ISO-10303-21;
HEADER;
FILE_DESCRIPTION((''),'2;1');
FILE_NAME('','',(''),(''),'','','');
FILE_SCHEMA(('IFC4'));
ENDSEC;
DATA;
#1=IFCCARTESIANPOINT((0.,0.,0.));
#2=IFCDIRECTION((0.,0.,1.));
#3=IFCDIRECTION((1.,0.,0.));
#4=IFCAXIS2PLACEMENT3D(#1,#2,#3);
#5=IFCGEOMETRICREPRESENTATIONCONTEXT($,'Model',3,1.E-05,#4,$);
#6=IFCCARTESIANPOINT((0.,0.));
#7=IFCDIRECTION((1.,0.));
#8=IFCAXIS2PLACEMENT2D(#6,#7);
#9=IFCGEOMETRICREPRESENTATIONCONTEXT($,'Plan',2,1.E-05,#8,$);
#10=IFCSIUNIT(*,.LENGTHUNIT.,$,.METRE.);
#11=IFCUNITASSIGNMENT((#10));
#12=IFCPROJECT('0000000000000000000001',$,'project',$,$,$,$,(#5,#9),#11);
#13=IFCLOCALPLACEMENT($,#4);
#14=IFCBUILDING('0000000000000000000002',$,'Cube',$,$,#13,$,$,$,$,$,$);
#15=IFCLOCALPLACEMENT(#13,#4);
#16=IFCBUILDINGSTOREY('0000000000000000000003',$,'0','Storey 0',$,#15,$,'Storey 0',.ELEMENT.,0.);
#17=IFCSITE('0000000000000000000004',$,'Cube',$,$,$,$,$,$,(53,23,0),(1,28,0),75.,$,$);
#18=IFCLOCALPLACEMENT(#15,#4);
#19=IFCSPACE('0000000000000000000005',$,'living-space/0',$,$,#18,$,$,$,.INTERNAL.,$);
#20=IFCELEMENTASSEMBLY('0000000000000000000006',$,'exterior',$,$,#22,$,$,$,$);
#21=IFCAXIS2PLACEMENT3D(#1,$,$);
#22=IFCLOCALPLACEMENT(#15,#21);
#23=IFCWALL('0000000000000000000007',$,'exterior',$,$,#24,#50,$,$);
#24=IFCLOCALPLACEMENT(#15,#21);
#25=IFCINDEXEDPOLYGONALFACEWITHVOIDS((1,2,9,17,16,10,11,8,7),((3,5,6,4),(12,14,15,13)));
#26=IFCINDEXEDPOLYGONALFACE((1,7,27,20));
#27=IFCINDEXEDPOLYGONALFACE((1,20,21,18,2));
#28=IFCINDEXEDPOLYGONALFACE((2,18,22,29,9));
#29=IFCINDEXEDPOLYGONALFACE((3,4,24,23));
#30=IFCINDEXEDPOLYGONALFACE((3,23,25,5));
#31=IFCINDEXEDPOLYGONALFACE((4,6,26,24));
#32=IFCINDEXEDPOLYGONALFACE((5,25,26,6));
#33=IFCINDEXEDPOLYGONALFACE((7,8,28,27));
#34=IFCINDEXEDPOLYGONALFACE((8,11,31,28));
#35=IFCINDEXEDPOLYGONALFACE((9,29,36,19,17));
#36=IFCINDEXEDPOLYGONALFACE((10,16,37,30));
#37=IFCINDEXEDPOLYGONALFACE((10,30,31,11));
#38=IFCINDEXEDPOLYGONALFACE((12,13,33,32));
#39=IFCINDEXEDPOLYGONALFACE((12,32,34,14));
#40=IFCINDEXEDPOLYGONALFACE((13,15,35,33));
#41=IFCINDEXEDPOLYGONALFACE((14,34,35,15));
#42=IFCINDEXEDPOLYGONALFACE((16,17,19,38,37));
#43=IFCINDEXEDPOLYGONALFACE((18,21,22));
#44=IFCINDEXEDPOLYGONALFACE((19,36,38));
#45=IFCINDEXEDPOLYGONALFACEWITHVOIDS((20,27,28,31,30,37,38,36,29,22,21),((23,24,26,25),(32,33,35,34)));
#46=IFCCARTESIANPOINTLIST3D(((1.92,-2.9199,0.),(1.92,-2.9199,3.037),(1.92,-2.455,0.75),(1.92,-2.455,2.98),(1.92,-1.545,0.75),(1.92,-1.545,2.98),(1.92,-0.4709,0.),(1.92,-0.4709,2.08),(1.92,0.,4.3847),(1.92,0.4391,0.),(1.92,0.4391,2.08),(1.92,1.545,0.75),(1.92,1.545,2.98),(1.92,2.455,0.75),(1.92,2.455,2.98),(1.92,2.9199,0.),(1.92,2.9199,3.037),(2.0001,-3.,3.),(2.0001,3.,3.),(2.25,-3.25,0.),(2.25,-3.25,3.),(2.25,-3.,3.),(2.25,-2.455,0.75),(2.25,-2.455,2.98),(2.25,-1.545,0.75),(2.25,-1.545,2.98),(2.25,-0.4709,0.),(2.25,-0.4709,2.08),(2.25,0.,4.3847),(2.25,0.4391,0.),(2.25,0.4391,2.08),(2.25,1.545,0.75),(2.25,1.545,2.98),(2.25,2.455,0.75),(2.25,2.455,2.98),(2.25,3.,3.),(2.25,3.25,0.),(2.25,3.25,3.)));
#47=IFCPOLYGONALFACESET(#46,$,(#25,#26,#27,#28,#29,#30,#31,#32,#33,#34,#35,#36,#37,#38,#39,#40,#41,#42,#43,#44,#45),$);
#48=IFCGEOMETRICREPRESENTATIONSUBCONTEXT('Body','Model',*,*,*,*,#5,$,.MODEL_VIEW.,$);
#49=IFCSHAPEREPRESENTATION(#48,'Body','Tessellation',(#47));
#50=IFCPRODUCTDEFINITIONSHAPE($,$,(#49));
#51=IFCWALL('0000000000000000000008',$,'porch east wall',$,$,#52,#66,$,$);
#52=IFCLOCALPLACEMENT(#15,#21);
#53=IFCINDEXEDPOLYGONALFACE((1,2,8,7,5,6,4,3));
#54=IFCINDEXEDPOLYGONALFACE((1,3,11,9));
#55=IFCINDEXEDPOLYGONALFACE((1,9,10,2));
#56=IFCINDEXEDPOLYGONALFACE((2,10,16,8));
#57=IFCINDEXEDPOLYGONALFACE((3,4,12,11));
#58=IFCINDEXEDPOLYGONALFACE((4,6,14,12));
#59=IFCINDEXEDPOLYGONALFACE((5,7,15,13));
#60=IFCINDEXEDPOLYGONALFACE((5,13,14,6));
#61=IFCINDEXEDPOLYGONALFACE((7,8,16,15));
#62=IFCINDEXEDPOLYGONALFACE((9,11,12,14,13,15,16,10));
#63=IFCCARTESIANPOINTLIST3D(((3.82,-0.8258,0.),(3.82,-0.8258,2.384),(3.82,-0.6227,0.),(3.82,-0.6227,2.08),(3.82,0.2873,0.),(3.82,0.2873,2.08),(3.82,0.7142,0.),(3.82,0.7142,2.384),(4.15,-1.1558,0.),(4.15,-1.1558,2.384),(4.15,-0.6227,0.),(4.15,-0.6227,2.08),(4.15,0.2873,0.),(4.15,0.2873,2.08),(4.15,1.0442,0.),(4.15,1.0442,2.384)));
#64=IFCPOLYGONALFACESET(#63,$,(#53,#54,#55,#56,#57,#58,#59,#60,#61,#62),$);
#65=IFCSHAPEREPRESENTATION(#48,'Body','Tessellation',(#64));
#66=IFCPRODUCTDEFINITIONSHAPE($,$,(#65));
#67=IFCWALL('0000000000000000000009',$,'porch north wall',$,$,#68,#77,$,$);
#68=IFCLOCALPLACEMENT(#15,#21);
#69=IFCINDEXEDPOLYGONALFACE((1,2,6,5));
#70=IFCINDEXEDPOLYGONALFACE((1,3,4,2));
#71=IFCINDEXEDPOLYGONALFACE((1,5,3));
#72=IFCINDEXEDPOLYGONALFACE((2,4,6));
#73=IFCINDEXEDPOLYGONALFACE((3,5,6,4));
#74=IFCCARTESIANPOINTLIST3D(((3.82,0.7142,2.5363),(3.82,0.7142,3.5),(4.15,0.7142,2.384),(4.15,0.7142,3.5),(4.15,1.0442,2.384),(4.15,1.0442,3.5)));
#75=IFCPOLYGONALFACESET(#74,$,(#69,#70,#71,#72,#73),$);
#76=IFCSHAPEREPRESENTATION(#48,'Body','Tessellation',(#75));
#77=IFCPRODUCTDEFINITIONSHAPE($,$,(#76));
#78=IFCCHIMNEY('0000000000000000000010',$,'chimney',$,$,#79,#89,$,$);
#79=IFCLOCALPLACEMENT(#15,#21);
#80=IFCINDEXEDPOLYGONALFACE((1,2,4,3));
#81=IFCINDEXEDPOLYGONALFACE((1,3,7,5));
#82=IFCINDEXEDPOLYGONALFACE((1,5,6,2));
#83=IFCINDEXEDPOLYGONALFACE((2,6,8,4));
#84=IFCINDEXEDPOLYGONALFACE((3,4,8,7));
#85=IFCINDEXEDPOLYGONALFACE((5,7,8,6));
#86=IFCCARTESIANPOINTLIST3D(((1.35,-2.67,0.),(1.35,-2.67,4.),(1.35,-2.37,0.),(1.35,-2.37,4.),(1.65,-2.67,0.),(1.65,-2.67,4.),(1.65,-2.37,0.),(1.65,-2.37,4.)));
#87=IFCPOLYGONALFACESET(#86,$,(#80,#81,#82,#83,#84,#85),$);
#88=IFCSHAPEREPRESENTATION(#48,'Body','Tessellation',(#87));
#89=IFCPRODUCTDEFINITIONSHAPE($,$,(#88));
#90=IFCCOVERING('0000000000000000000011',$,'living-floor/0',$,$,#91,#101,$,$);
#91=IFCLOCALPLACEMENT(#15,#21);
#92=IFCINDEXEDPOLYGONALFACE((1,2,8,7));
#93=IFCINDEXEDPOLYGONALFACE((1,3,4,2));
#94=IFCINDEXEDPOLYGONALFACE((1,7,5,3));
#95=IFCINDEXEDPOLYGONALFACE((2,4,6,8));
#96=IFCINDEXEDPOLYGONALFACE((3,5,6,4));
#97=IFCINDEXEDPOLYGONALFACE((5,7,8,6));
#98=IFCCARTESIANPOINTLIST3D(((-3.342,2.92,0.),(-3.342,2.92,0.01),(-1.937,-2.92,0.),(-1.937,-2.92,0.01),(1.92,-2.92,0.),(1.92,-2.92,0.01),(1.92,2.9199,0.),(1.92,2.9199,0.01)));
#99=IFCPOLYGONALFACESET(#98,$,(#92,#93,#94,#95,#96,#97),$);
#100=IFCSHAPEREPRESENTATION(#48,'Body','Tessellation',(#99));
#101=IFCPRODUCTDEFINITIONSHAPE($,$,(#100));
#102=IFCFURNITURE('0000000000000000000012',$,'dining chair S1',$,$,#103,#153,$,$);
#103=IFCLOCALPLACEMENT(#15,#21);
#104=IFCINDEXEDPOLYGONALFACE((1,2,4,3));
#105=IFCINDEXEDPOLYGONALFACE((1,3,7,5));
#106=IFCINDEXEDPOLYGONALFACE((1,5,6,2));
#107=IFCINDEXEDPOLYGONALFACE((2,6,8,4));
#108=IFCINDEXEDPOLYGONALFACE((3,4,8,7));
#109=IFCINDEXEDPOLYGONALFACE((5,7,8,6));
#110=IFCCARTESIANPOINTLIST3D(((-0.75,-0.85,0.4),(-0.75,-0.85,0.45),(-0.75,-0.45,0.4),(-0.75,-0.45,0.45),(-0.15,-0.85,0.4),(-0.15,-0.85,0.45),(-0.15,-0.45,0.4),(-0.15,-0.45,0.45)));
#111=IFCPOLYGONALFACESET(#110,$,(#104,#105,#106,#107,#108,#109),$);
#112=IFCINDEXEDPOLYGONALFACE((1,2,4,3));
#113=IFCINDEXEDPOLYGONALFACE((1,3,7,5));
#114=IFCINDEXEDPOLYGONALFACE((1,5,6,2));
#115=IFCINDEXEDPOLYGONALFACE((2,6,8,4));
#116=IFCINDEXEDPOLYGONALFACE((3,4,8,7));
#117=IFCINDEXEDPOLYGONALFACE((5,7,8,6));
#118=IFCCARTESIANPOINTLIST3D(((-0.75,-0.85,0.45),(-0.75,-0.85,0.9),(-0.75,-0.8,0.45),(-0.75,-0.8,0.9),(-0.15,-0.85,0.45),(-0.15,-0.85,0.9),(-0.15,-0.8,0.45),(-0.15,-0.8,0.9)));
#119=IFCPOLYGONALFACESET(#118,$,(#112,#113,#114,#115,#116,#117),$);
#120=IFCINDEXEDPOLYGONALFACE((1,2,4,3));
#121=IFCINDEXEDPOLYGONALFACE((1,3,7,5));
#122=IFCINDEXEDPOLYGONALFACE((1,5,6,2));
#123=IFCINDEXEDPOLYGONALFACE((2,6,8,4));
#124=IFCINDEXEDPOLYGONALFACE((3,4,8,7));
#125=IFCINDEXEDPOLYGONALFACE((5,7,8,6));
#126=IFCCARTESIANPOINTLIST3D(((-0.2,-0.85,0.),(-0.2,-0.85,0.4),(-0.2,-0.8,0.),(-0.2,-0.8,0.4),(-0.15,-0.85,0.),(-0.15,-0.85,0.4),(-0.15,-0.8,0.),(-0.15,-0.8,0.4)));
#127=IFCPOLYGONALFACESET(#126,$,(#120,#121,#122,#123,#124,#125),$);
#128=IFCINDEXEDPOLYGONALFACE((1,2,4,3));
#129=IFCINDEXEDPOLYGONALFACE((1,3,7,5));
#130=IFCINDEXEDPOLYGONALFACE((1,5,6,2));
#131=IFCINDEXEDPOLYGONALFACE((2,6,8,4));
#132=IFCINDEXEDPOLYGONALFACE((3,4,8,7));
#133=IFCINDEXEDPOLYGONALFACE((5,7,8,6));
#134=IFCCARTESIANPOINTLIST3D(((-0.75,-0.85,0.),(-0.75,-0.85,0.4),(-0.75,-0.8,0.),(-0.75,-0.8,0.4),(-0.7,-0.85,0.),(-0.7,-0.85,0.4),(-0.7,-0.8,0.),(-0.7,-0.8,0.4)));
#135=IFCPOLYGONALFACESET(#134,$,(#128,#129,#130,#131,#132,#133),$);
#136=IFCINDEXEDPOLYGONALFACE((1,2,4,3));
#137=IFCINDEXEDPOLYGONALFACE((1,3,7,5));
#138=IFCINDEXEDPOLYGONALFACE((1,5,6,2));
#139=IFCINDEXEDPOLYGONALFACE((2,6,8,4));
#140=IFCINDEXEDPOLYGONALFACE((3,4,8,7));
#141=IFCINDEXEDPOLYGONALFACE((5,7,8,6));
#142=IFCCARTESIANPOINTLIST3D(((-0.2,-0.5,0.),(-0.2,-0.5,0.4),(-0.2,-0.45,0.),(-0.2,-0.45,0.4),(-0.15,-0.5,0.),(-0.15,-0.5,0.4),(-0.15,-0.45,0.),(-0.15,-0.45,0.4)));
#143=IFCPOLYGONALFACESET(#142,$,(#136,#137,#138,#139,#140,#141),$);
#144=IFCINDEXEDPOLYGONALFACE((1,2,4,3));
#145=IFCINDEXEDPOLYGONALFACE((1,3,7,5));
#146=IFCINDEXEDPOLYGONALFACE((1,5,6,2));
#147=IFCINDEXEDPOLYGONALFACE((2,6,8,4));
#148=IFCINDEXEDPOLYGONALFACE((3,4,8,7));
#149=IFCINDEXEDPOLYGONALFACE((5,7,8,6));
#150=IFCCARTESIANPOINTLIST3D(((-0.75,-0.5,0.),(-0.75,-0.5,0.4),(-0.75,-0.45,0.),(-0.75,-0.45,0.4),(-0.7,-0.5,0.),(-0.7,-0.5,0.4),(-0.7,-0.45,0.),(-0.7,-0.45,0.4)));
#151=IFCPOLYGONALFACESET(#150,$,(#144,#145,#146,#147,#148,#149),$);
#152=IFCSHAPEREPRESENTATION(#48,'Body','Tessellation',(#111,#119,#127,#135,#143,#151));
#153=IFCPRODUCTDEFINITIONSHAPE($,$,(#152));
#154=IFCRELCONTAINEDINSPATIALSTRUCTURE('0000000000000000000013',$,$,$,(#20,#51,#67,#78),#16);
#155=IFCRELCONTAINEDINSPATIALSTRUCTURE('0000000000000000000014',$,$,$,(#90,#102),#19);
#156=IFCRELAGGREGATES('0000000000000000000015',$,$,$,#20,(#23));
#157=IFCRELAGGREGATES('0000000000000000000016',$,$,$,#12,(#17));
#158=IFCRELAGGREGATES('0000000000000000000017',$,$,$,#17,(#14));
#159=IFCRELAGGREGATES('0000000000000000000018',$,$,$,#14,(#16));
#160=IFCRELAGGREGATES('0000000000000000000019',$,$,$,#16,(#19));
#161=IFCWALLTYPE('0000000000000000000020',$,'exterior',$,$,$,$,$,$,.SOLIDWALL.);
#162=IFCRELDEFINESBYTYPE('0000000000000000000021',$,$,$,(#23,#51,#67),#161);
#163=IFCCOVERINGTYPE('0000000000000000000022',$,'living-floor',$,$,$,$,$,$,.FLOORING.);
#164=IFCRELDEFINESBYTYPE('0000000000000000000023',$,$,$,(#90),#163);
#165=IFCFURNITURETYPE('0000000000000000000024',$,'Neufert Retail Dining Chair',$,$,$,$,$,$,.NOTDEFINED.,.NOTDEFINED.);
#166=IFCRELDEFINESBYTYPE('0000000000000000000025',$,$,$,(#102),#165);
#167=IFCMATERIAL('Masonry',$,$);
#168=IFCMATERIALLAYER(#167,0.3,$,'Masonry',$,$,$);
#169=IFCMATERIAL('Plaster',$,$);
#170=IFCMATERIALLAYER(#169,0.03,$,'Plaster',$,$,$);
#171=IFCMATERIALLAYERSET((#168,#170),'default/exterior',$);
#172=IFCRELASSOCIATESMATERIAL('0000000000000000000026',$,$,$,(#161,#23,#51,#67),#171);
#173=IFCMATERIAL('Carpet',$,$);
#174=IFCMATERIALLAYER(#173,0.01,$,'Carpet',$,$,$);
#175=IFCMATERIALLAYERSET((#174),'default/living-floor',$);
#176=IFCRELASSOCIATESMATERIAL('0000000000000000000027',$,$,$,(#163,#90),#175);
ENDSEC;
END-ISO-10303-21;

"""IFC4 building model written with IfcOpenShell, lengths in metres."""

from ifc_helpers import new_model, entity, si_unit, frame, origin, origin_with_axes, origin_2d_with_axis, place, context, subcontext, project, spatial, polyline, line, indexed_curve, outline, extrude, clip, halfspace, bounded_halfspace, shape, source, transform, mapped, material, layer, layer_set, layer_usage, type_object, type_shapes, element, aggregate, save


model = new_model("IFC4")

# Units and contexts
model_context = context("Model", 3, precision=1e-05, world=origin_with_axes())
plan_context = context("Plan", 2, precision=1e-05, world=origin_2d_with_axis())
body_context_1 = subcontext(model_context, "Body", "Model", "MODEL_VIEW")
body_context_2 = subcontext(plan_context, "Body", "Plan", "PLAN_VIEW")
ifc_project = project(units=[si_unit("LENGTHUNIT", "METRE")], contexts=[model_context, plan_context])

# Site, building, storey
site = spatial("IfcSite", under=ifc_project, Name="Cube", RefLatitude=(53, 23, 0), RefLongitude=(1, 28, 0), RefElevation=75.0)
building_placement = place(None, origin_with_axes())
building = spatial("IfcBuilding", under=site, at=building_placement, Name="Cube")
storey_placement = place(building_placement, origin_with_axes())
storey = spatial("IfcBuildingStorey", under=building, at=storey_placement, Name="0", Description="Storey 0", LongName="Storey 0", CompositionType="ELEMENT", Elevation=0.0)

# Element assembly, wall, openings
ifc_material_1 = material(Name="Masonry")
ifc_layer_1 = layer(ifc_material_1, 0.3, Name="Masonry")
ifc_material_2 = material(Name="Plaster")
ifc_layer_2 = layer(ifc_material_2, 0.03, Name="Plaster")
ifc_layer_set_1 = layer_set([ifc_layer_1, ifc_layer_2], Name="default/exterior")
wall_type = type_object("IfcWallType", Name="exterior", PredefinedType="SOLIDWALL", material=ifc_layer_set_1)
assembly_1_placement = place(storey_placement, frame((2.0, -3.0, 0.0), z_axis=(0.0, 0.0, 1.0), x_axis=(0.0, 1.0, 0.0)))
assembly_1 = element("IfcElementAssembly", 1, at=assembly_1_placement, inside=storey, Name="exterior")
ifc_layer_usage_1 = layer_usage(ifc_layer_set_1, "AXIS2", "POSITIVE", -0.25)
wall_1_placement = place(assembly_1_placement, origin_with_axes())
wall_1 = element("IfcWall", 2, at=wall_1_placement, type_object=wall_type, material=ifc_layer_usage_1, Name="exterior", context=body_context_1, shape_type="Clipping", body=[
    clip(clip(clip(clip(extrude(outline(polyline([(0.0801, 0.08), (-0.25, -0.25), (6.25, -0.25), (5.9199, 0.08), (0.0801, 0.08)])), origin(), (0.0, 0.0, 1.0), 4.385), bounded_halfspace(frame((6.0, 0.0, 3.0), z_axis=(0.419069, 0.0, 0.907954), x_axis=(0.0, -1.0, 0.0)), False, origin(), polyline([(6.0, -1.0), (3.0, -1.0), (3.0, 1.0), (6.0, 1.0), (6.0, -1.0)]))), bounded_halfspace(frame((6.0, 0.0, 3.0), z_axis=(0.0, 0.0, 1.0), x_axis=(0.0, 1.0, 0.0)), False, origin(), polyline([(6.0, 1.0), (7.0, 1.0), (7.0, -1.0), (6.0, -1.0), (6.0, 1.0)]))), bounded_halfspace(frame((3.0, 0.0, 4.3847), z_axis=(-0.419069, 0.0, 0.907954), x_axis=(0.0, -1.0, 0.0)), False, origin(), polyline([(3.0, -1.0), (0.0, -1.0), (0.0, 1.0), (3.0, 1.0), (3.0, -1.0)]))), bounded_halfspace(frame((0.0, 0.0, 3.0), z_axis=(0.0, 0.0, 1.0), x_axis=(0.0, -1.0, 0.0)), False, origin(), polyline([(0.0, -1.0), (-1.0, -1.0), (-1.0, 1.0), (0.0, 1.0), (0.0, -1.0)]))),
])
opening_1_placement = place(wall_1_placement, frame((0.545, -0.25, 0.75), z_axis=(0.0, 0.0, 1.0), x_axis=(1.0, 0.0, 0.0)))
element("IfcOpeningElement", 3, at=opening_1_placement, cuts=wall_1, PredefinedType="OPENING", context=body_context_1, shape_type="SweptSolid", body=[
    extrude(outline(polyline([(0.0, -0.02), (0.91, -0.02), (0.91, 0.35), (0.0, 0.35), (0.0, -0.02)])), origin(), (0.0, 0.0, 1.0), 2.23),
])
opening_2_placement = place(wall_1_placement, frame((4.545, -0.25, 0.75), z_axis=(0.0, 0.0, 1.0), x_axis=(1.0, 0.0, 0.0)))
element("IfcOpeningElement", 4, at=opening_2_placement, cuts=wall_1, PredefinedType="OPENING", context=body_context_1, shape_type="SweptSolid", body=[
    extrude(outline(polyline([(0.0, -0.02), (0.91, -0.02), (0.91, 0.35), (0.0, 0.35), (0.0, -0.02)])), origin(), (0.0, 0.0, 1.0), 2.23),
])
shared_shape_1 = source(origin_with_axes(), body_context_1, "Body", "SweptSolid", [
    extrude(outline(indexed_curve([(0.0, 0.0), (0.91, 0.0), (0.91, 2.08), (0.0, 2.08)], segments=[line(1, 2, 3, 4, 1)])), frame((0.0, -0.6, 0.0), z_axis=(0.0, -1.0, 0.0), x_axis=(1.0, 0.0, 0.0)), (0.0, 0.0, -1.0), 1.2),
])
opening_3_placement = place(wall_1_placement, frame((2.5291, -0.25, 0.0), z_axis=(0.0, 0.0, 1.0), x_axis=(1.0, 0.0, 0.0)))
element("IfcOpeningElement", 5, at=opening_3_placement, cuts=wall_1, PredefinedType="OPENING", context=body_context_1, shape_type="MappedRepresentation", body=[
    mapped(shared_shape_1, transform((0.0, 0.0, 0.0), x_axis=(1.0, 0.0, 0.0), y_axis=(0.0, 1.0, 0.0), z_axis=(0.0, 0.0, 1.0), scale=1.0)),
])
aggregate(assembly_1, [wall_1])

# Wall, opening
ifc_layer_usage_2 = layer_usage(ifc_layer_set_1, "AXIS2", "POSITIVE", 0.0)
wall_2_placement = place(storey_placement, frame((4.15, -1.1558, 0.0), z_axis=(0.0, 0.0, 1.0), x_axis=(0.0, 1.0, 0.0)))
wall_2 = element("IfcWall", 6, at=wall_2_placement, inside=storey, type_object=wall_type, material=ifc_layer_usage_2, Name="porch east wall", context=body_context_1, shape_type="SweptSolid", body=[
    extrude(outline(indexed_curve([(0.0, 0.0), (0.33, 0.33), (1.87, 0.33), (2.2, 0.0)], segments=[line(1, 2, 3, 4, 1)])), origin_with_axes(), (0.0, 0.0, 1.0), 2.384),
])
shared_shape_2 = source(origin_with_axes(), body_context_1, "Body", "SweptSolid", [
    extrude(outline(indexed_curve([(0.0, 0.0), (0.91, 0.0), (0.91, 2.08), (0.0, 2.08)], segments=[line(1, 2, 3, 4, 1)])), frame((0.0, -0.6, 0.0), z_axis=(0.0, -1.0, 0.0), x_axis=(1.0, 0.0, 0.0)), (0.0, 0.0, -1.0), 1.2),
])
opening_4_placement = place(wall_2_placement, frame((0.5331, 0.0, 0.0), z_axis=(0.0, 0.0, 1.0), x_axis=(1.0, 0.0, 0.0)))
element("IfcOpeningElement", 7, at=opening_4_placement, cuts=wall_2, PredefinedType="OPENING", context=body_context_1, shape_type="MappedRepresentation", body=[
    mapped(shared_shape_2, transform((0.0, 0.0, 0.0), x_axis=(1.0, 0.0, 0.0), y_axis=(0.0, 1.0, 0.0), z_axis=(0.0, 0.0, 1.0), scale=1.0)),
])

# Wall
ifc_layer_usage_3 = layer_usage(ifc_layer_set_1, "AXIS2", "POSITIVE", 0.0)
wall_3_placement = place(storey_placement, frame((4.15, 1.0442, 0.0), z_axis=(0.0, 0.0, 1.0), x_axis=(-1.0, 0.0, 0.0)))
element("IfcWall", 8, at=wall_3_placement, inside=storey, type_object=wall_type, material=ifc_layer_usage_3, Name="porch north wall", context=body_context_1, shape_type="Clipping", body=[
    clip(clip(extrude(outline(indexed_curve([(0.0, 0.0), (0.0, 0.33), (1.9, 0.33), (1.9, 0.0), (0.0, 0.0)], self_intersect=False)), origin_with_axes(), (0.0, 0.0, 1.0), 3.5), halfspace(frame((0.0, 0.0, 0.0), z_axis=(0.707, -0.707, 0.0), x_axis=(-0.707107, -0.707107, 0.0)), False)), halfspace(frame((0.0, 0.0, 2.384), z_axis=(0.419, 0.0, -0.908), x_axis=(0.0, -1.0, 0.0)), False)),
])

# Chimney
chimney_placement = place(storey_placement, frame((1.35, -2.67, 0.0), z_axis=(0.0, 0.0, 1.0), x_axis=(1.0, 0.0, 0.0)))
element("IfcChimney", 9, at=chimney_placement, inside=storey, Name="chimney", context=body_context_1, shape_type="SweptSolid", body=[
    extrude(outline(indexed_curve([(0.0, 0.0), (0.3, 0.0), (0.3, 0.3), (0.0, 0.3)])), None, (0.0, 0.0, 1.0), 4.0),
])

# Shared definitions
space_placement = place(storey_placement, origin_with_axes())
space = spatial("IfcSpace", under=storey, at=space_placement, Name="living-space/0", PredefinedType="INTERNAL")

# Covering
ifc_material_3 = material(Name="Carpet")
ifc_layer_3 = layer(ifc_material_3, 0.01, Name="Carpet")
ifc_layer_set_2 = layer_set([ifc_layer_3], Name="default/living-floor")
ifc_layer_usage_4 = layer_usage(ifc_layer_set_2, "AXIS3", "POSITIVE", 0.0)
covering_type = type_object("IfcCoveringType", Name="living-floor", PredefinedType="FLOORING", material=ifc_layer_set_2)
covering_placement = place(space_placement, origin_with_axes())
element("IfcCovering", 10, at=covering_placement, inside=space, type_object=covering_type, material=ifc_layer_usage_4, Name="living-floor/0", context=body_context_1, shape_type="SweptSolid", body=[
    extrude(outline(polyline([(1.92, 2.9199), (-3.342, 2.92), (-1.937, -2.92), (1.92, -2.92), (1.92, 2.9199)])), origin_with_axes(), (0.0, 0.0, 1.0), 0.01),
])

# Furniture
furniture_type_1 = type_object("IfcFurnitureType", Name="Neufert Retail Dining Chair", AssemblyPlace="NOTDEFINED", PredefinedType="NOTDEFINED")
shared_shape_3 = source(origin_with_axes(), body_context_1, "Body", "SweptSolid", [
    extrude(outline(indexed_curve([(-0.3, 0.0), (0.3, 0.0), (0.3, -0.4), (-0.3, -0.4)], segments=[line(1, 2, 3, 4, 1)])), frame((0.0, 0.0, 0.45), z_axis=(0.0, 0.0, 1.0), x_axis=(1.0, 0.0, 0.0)), (0.0, 0.0, -1.0), 0.05),
    extrude(outline(indexed_curve([(-0.3, 0.0), (0.3, 0.0), (0.3, -0.05), (-0.3, -0.05)], segments=[line(1, 2, 3, 4, 1)])), frame((0.0, 0.0, 0.9), z_axis=(0.0, 0.0, 1.0), x_axis=(1.0, 0.0, 0.0)), (0.0, 0.0, -1.0), 0.45),
    extrude(outline(indexed_curve([(-0.3, 0.0), (-0.25, 0.0), (-0.25, -0.05), (-0.3, -0.05)], segments=[line(1, 2, 3, 4, 1)])), origin_with_axes(), (0.0, 0.0, 1.0), 0.4),
    extrude(outline(indexed_curve([(0.3, 0.0), (0.25, 0.0), (0.25, -0.05), (0.3, -0.05)], segments=[line(1, 2, 3, 4, 1)])), origin_with_axes(), (0.0, 0.0, 1.0), 0.4),
    extrude(outline(indexed_curve([(-0.3, -0.4), (-0.25, -0.4), (-0.25, -0.35), (-0.3, -0.35)], segments=[line(1, 2, 3, 4, 1)])), origin_with_axes(), (0.0, 0.0, 1.0), 0.4),
    extrude(outline(indexed_curve([(0.3, -0.4), (0.25, -0.4), (0.25, -0.35), (0.3, -0.35)], segments=[line(1, 2, 3, 4, 1)])), origin_with_axes(), (0.0, 0.0, 1.0), 0.4),
])
shared_shape_4 = source(origin_with_axes(), body_context_2, "Body", "Curve2D", [
    entity("IfcIndexedPolyCurve", entity("IfcCartesianPointList2D", [[-0.3, -0.4], [0.3, -0.4]])),
    entity("IfcIndexedPolyCurve", entity("IfcCartesianPointList2D", [[-0.3, -0.4], [-0.3, -0.3], [-0.2121, -0.0879], [0.0, 0.0], [0.2121, -0.0879], [0.3, -0.3], [0.3, -0.4]]), [entity("IfcLineIndex", [1, 2]), entity("IfcArcIndex", [2, 3, 4]), entity("IfcArcIndex", [4, 5, 6]), entity("IfcLineIndex", [6, 7])]),
    entity("IfcIndexedPolyCurve", entity("IfcCartesianPointList2D", [[-0.26, -0.4], [-0.26, -0.3], [-0.1838, -0.1162], [0.0, -0.04], [0.1838, -0.1162], [0.26, -0.3], [0.26, -0.4]]), [entity("IfcLineIndex", [1, 2]), entity("IfcArcIndex", [2, 3, 4]), entity("IfcArcIndex", [4, 5, 6]), entity("IfcLineIndex", [6, 7])]),
])
type_shapes(furniture_type_1, [shared_shape_3, shared_shape_4])
for number, where, z_axis, x_axis, name in (
    (11, (-0.45, -0.85, 0.0), (0.0, 0.0, 1.0), (-1.0, 0.0, 0.0), "dining chair S1"),
):
    element("IfcFurniture", number, at=place(space_placement, frame(where, z_axis=z_axis, x_axis=x_axis)), inside=space, type_object=furniture_type_1, Name=name, shapes=[
        shape(body_context_1, "Body", "MappedRepresentation", [mapped(shared_shape_3, transform((0.0, 0.0, 0.0), x_axis=(1.0, 0.0, 0.0), y_axis=(0.0, 1.0, 0.0), z_axis=(0.0, 0.0, 1.0), scale=1.0))]),
        shape(body_context_2, "Body", "MappedRepresentation", [mapped(shared_shape_4, transform((0.0, 0.0, 0.0), x_axis=(1.0, 0.0, 0.0), y_axis=(0.0, 1.0, 0.0), z_axis=(0.0, 0.0, 1.0), scale=1.0))]),
    ])

save(model, "model.ifc")
